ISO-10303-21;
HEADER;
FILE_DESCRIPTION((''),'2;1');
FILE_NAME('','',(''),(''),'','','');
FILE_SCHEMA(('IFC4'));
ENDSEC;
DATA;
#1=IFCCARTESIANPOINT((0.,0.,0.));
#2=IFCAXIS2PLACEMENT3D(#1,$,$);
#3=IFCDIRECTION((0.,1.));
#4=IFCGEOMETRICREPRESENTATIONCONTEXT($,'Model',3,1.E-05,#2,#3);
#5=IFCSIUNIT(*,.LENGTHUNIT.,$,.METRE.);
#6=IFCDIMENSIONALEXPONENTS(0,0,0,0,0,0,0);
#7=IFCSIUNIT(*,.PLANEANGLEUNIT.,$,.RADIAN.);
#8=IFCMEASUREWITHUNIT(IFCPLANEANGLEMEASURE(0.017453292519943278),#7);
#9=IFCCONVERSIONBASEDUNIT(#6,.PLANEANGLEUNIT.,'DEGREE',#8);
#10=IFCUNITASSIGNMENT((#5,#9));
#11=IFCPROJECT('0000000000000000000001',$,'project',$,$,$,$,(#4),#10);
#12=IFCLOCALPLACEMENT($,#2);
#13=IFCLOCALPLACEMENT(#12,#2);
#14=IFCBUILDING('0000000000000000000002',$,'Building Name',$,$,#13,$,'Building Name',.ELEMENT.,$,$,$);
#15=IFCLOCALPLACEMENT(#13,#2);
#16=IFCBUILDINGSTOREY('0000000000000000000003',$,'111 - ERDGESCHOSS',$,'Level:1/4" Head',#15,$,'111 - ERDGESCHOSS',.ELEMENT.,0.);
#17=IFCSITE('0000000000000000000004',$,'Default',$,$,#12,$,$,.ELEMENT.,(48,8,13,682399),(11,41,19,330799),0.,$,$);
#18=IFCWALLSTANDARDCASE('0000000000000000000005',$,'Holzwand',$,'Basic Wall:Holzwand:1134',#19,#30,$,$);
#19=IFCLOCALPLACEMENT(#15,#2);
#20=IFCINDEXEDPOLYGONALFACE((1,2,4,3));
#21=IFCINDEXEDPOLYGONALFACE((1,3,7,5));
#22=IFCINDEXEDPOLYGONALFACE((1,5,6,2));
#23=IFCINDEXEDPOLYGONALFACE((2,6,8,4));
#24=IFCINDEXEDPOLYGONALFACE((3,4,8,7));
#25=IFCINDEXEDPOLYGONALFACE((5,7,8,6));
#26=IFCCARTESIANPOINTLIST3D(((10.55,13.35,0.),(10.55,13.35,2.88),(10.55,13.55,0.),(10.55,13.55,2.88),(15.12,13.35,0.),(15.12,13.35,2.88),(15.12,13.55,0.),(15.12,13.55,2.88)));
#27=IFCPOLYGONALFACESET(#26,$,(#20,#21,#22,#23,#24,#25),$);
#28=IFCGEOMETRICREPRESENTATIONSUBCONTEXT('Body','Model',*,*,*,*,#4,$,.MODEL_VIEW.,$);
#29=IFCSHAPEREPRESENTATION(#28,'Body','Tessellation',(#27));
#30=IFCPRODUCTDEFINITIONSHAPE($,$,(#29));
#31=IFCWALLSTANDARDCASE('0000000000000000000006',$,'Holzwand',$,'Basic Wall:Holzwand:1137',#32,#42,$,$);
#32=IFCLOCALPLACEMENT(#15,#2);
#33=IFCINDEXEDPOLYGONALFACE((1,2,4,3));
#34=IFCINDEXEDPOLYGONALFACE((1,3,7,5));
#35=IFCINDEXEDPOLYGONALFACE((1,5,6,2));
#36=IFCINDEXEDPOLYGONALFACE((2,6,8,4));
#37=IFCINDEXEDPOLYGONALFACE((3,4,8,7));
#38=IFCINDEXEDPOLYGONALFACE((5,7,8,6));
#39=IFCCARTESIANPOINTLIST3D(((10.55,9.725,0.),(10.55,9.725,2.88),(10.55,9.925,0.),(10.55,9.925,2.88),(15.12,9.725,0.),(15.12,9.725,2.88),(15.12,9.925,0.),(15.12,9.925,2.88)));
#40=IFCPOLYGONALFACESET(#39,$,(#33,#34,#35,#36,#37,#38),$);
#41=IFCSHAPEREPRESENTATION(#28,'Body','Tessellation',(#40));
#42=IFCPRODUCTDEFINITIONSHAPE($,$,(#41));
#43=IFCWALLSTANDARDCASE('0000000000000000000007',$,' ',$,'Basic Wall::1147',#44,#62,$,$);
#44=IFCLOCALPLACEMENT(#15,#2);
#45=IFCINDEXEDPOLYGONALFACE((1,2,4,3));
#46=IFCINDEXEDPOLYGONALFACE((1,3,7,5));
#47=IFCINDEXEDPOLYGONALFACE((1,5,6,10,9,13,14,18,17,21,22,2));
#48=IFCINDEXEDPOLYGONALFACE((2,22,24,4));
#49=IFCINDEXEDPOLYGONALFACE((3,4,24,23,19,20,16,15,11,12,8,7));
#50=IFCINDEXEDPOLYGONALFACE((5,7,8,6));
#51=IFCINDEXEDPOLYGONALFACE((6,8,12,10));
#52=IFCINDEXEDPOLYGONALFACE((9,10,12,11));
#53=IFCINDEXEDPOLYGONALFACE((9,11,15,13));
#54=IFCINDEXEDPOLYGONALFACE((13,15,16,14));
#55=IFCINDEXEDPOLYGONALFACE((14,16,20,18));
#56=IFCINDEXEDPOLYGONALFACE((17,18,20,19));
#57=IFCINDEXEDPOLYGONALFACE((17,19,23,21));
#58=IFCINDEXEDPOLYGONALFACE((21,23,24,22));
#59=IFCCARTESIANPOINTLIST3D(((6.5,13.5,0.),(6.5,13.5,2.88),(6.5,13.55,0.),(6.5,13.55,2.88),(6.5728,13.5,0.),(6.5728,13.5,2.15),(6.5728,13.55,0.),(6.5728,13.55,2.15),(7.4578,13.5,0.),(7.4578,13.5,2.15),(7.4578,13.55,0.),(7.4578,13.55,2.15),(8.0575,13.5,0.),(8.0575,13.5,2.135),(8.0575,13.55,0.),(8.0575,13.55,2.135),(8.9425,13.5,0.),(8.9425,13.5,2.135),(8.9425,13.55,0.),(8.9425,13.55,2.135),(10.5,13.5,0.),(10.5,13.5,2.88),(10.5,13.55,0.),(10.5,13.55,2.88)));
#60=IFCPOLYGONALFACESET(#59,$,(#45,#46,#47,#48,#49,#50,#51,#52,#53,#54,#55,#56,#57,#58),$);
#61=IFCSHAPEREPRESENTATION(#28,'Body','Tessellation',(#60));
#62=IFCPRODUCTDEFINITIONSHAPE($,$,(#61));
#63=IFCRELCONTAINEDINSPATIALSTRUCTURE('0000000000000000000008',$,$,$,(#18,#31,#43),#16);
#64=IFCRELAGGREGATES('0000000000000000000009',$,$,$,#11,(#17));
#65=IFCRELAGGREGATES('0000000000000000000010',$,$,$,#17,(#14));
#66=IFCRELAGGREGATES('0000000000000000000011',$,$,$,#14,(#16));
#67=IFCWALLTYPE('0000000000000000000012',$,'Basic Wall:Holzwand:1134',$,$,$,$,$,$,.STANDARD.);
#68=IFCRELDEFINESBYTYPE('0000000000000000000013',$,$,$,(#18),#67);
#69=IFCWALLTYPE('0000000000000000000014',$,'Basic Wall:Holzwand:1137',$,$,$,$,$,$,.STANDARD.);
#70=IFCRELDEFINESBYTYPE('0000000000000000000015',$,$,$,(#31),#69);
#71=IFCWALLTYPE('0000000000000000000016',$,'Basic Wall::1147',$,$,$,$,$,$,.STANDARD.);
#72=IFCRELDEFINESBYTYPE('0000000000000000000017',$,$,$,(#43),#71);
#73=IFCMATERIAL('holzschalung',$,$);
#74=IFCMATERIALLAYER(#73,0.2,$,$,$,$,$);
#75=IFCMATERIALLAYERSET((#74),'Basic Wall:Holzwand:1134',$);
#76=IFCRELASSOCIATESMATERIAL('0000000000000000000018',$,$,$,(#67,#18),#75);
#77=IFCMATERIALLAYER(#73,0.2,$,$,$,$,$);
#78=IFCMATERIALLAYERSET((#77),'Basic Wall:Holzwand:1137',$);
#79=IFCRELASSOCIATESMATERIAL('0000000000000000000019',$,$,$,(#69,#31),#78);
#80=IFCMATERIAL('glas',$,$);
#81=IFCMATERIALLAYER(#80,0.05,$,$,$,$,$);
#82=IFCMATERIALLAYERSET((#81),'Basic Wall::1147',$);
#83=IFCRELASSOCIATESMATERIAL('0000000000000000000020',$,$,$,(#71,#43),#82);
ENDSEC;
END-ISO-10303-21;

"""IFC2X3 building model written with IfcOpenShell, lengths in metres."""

from ifc_helpers import new_model, entity, si_unit, converted_unit, direction, frame, frame_2d, origin, origin_2d_with_axis, place, context, subcontext, project, spatial, rectangle, extrude, material, layer, layer_set, layer_usage, type_object, element, save


model = new_model("IFC2X3")

# Units and contexts
model_context = context("Model", 3, precision=1e-05, world=origin(), true_north=direction((0.0, 1.0)))
body_context = subcontext(model_context, "Body", "Model", "MODEL_VIEW")
ifc_project = project(units=[si_unit("LENGTHUNIT", "METRE"), converted_unit("PLANEANGLEUNIT", "DEGREE", entity("IfcPlaneAngleMeasure", 0.017453292519943278), si_unit("PLANEANGLEUNIT", "RADIAN"), dimensions=[0, 0, 0, 0, 0, 0, 0])], contexts=[model_context])

# Site, building, storey
site_placement = place(None, origin())
site = spatial("IfcSite", under=ifc_project, at=site_placement, Name="Default", CompositionType="ELEMENT", RefLatitude=(48, 8, 13, 682399), RefLongitude=(11, 41, 19, 330799), RefElevation=0.0)
building_placement = place(site_placement, origin())
building = spatial("IfcBuilding", under=site, at=building_placement, Name="Building Name", LongName="Building Name", CompositionType="ELEMENT")
storey_placement = place(building_placement, origin())
storey = spatial("IfcBuildingStorey", under=building, at=storey_placement, Name="111 - ERDGESCHOSS", ObjectType="Level:1/4\" Head", LongName="111 - ERDGESCHOSS", CompositionType="ELEMENT", Elevation=0.0)

# Shared definitions
ifc_material_1 = material(Name="holzschalung")

# Walls
ifc_layer_1 = layer(ifc_material_1, 0.2)
ifc_layer_set_1 = layer_set([ifc_layer_1], Name="Basic Wall:Holzwand:1134")
ifc_layer_usage_1 = layer_usage(ifc_layer_set_1, "AXIS2", "NEGATIVE", 0.1)
wall_type_1 = type_object("IfcWallType", Name="Basic Wall:Holzwand:1134", PredefinedType="STANDARD", material=ifc_layer_set_1)
wall_1_placement = place(storey_placement, frame((10.55, 13.45, 0.0)))
element("IfcWallStandardCase", 1, at=wall_1_placement, inside=storey, type_object=wall_type_1, material=ifc_layer_usage_1, Name="Holzwand", ObjectType="Basic Wall:Holzwand:1134", context=body_context, shape_type="SweptSolid", body=[
    extrude(rectangle(XDim=4.57, YDim=0.2, at=frame_2d((2.285, 0.0), x_axis=(-1.0, 0.0))), origin(), (0.0, 0.0, 1.0), 2.88),
])
ifc_layer_2 = layer(ifc_material_1, 0.2)
ifc_layer_set_2 = layer_set([ifc_layer_2], Name="Basic Wall:Holzwand:1137")
ifc_layer_usage_2 = layer_usage(ifc_layer_set_2, "AXIS2", "NEGATIVE", 0.1)
wall_type_2 = type_object("IfcWallType", Name="Basic Wall:Holzwand:1137", PredefinedType="STANDARD", material=ifc_layer_set_2)
wall_2_placement = place(storey_placement, frame((15.12, 9.825, 0.0), z_axis=(0.0, 0.0, 1.0), x_axis=(-1.0, 0.0, 0.0)))
element("IfcWallStandardCase", 2, at=wall_2_placement, inside=storey, type_object=wall_type_2, material=ifc_layer_usage_2, Name="Holzwand", ObjectType="Basic Wall:Holzwand:1137", context=body_context, shape_type="SweptSolid", body=[
    extrude(rectangle(XDim=4.57, YDim=0.2, at=frame_2d((2.285, 0.0), x_axis=(-1.0, 0.0))), origin(), (0.0, 0.0, 1.0), 2.88),
])

# Wall, openings
ifc_material_2 = material(Name="glas")
ifc_layer_3 = layer(ifc_material_2, 0.05)
ifc_layer_set_3 = layer_set([ifc_layer_3], Name="Basic Wall::1147")
ifc_layer_usage_3 = layer_usage(ifc_layer_set_3, "AXIS2", "NEGATIVE", 0.025)
wall_type_3 = type_object("IfcWallType", Name="Basic Wall::1147", PredefinedType="STANDARD", material=ifc_layer_set_3)
wall_3_placement = place(storey_placement, frame((6.5, 13.525, 0.0)))
wall_3 = element("IfcWallStandardCase", 3, at=wall_3_placement, inside=storey, type_object=wall_type_3, material=ifc_layer_usage_3, Name=" ", ObjectType="Basic Wall::1147", context=body_context, shape_type="SweptSolid", body=[
    extrude(rectangle(XDim=4.0, YDim=0.05, at=frame_2d((2.0, 0.0), x_axis=(1.0, 0.0))), origin(), (0.0, 0.0, 1.0), 2.88),
])
opening_1_placement = place(wall_3_placement, frame((-6.5, -13.525, 0.0)))
element("IfcOpeningElement", 4, at=opening_1_placement, cuts=wall_3, ObjectType="Opening", context=body_context, shape_type="SweptSolid", body=[
    extrude(rectangle(XDim=2.3, YDim=0.885, at=origin_2d_with_axis()), frame((7.0153, 13.4995, 1.0), z_axis=(0.0, 1.0, 0.0), x_axis=(0.0, 0.0, 1.0)), (0.0, 0.0, 1.0), 0.051),
])
opening_2_placement = place(wall_3_placement, frame((-6.5, -13.525, 0.0)))
element("IfcOpeningElement", 5, at=opening_2_placement, cuts=wall_3, ObjectType="Opening", context=body_context, shape_type="SweptSolid", body=[
    extrude(rectangle(XDim=2.135, YDim=0.885, at=frame_2d((0.0, 0.0), x_axis=(0.0, 1.0))), frame((8.5, 13.4995, 1.0675), z_axis=(0.0, 1.0, 0.0), x_axis=(-1.0, 0.0, 0.0)), (0.0, 0.0, 1.0), 0.051),
])

save(model, "model.ifc")
